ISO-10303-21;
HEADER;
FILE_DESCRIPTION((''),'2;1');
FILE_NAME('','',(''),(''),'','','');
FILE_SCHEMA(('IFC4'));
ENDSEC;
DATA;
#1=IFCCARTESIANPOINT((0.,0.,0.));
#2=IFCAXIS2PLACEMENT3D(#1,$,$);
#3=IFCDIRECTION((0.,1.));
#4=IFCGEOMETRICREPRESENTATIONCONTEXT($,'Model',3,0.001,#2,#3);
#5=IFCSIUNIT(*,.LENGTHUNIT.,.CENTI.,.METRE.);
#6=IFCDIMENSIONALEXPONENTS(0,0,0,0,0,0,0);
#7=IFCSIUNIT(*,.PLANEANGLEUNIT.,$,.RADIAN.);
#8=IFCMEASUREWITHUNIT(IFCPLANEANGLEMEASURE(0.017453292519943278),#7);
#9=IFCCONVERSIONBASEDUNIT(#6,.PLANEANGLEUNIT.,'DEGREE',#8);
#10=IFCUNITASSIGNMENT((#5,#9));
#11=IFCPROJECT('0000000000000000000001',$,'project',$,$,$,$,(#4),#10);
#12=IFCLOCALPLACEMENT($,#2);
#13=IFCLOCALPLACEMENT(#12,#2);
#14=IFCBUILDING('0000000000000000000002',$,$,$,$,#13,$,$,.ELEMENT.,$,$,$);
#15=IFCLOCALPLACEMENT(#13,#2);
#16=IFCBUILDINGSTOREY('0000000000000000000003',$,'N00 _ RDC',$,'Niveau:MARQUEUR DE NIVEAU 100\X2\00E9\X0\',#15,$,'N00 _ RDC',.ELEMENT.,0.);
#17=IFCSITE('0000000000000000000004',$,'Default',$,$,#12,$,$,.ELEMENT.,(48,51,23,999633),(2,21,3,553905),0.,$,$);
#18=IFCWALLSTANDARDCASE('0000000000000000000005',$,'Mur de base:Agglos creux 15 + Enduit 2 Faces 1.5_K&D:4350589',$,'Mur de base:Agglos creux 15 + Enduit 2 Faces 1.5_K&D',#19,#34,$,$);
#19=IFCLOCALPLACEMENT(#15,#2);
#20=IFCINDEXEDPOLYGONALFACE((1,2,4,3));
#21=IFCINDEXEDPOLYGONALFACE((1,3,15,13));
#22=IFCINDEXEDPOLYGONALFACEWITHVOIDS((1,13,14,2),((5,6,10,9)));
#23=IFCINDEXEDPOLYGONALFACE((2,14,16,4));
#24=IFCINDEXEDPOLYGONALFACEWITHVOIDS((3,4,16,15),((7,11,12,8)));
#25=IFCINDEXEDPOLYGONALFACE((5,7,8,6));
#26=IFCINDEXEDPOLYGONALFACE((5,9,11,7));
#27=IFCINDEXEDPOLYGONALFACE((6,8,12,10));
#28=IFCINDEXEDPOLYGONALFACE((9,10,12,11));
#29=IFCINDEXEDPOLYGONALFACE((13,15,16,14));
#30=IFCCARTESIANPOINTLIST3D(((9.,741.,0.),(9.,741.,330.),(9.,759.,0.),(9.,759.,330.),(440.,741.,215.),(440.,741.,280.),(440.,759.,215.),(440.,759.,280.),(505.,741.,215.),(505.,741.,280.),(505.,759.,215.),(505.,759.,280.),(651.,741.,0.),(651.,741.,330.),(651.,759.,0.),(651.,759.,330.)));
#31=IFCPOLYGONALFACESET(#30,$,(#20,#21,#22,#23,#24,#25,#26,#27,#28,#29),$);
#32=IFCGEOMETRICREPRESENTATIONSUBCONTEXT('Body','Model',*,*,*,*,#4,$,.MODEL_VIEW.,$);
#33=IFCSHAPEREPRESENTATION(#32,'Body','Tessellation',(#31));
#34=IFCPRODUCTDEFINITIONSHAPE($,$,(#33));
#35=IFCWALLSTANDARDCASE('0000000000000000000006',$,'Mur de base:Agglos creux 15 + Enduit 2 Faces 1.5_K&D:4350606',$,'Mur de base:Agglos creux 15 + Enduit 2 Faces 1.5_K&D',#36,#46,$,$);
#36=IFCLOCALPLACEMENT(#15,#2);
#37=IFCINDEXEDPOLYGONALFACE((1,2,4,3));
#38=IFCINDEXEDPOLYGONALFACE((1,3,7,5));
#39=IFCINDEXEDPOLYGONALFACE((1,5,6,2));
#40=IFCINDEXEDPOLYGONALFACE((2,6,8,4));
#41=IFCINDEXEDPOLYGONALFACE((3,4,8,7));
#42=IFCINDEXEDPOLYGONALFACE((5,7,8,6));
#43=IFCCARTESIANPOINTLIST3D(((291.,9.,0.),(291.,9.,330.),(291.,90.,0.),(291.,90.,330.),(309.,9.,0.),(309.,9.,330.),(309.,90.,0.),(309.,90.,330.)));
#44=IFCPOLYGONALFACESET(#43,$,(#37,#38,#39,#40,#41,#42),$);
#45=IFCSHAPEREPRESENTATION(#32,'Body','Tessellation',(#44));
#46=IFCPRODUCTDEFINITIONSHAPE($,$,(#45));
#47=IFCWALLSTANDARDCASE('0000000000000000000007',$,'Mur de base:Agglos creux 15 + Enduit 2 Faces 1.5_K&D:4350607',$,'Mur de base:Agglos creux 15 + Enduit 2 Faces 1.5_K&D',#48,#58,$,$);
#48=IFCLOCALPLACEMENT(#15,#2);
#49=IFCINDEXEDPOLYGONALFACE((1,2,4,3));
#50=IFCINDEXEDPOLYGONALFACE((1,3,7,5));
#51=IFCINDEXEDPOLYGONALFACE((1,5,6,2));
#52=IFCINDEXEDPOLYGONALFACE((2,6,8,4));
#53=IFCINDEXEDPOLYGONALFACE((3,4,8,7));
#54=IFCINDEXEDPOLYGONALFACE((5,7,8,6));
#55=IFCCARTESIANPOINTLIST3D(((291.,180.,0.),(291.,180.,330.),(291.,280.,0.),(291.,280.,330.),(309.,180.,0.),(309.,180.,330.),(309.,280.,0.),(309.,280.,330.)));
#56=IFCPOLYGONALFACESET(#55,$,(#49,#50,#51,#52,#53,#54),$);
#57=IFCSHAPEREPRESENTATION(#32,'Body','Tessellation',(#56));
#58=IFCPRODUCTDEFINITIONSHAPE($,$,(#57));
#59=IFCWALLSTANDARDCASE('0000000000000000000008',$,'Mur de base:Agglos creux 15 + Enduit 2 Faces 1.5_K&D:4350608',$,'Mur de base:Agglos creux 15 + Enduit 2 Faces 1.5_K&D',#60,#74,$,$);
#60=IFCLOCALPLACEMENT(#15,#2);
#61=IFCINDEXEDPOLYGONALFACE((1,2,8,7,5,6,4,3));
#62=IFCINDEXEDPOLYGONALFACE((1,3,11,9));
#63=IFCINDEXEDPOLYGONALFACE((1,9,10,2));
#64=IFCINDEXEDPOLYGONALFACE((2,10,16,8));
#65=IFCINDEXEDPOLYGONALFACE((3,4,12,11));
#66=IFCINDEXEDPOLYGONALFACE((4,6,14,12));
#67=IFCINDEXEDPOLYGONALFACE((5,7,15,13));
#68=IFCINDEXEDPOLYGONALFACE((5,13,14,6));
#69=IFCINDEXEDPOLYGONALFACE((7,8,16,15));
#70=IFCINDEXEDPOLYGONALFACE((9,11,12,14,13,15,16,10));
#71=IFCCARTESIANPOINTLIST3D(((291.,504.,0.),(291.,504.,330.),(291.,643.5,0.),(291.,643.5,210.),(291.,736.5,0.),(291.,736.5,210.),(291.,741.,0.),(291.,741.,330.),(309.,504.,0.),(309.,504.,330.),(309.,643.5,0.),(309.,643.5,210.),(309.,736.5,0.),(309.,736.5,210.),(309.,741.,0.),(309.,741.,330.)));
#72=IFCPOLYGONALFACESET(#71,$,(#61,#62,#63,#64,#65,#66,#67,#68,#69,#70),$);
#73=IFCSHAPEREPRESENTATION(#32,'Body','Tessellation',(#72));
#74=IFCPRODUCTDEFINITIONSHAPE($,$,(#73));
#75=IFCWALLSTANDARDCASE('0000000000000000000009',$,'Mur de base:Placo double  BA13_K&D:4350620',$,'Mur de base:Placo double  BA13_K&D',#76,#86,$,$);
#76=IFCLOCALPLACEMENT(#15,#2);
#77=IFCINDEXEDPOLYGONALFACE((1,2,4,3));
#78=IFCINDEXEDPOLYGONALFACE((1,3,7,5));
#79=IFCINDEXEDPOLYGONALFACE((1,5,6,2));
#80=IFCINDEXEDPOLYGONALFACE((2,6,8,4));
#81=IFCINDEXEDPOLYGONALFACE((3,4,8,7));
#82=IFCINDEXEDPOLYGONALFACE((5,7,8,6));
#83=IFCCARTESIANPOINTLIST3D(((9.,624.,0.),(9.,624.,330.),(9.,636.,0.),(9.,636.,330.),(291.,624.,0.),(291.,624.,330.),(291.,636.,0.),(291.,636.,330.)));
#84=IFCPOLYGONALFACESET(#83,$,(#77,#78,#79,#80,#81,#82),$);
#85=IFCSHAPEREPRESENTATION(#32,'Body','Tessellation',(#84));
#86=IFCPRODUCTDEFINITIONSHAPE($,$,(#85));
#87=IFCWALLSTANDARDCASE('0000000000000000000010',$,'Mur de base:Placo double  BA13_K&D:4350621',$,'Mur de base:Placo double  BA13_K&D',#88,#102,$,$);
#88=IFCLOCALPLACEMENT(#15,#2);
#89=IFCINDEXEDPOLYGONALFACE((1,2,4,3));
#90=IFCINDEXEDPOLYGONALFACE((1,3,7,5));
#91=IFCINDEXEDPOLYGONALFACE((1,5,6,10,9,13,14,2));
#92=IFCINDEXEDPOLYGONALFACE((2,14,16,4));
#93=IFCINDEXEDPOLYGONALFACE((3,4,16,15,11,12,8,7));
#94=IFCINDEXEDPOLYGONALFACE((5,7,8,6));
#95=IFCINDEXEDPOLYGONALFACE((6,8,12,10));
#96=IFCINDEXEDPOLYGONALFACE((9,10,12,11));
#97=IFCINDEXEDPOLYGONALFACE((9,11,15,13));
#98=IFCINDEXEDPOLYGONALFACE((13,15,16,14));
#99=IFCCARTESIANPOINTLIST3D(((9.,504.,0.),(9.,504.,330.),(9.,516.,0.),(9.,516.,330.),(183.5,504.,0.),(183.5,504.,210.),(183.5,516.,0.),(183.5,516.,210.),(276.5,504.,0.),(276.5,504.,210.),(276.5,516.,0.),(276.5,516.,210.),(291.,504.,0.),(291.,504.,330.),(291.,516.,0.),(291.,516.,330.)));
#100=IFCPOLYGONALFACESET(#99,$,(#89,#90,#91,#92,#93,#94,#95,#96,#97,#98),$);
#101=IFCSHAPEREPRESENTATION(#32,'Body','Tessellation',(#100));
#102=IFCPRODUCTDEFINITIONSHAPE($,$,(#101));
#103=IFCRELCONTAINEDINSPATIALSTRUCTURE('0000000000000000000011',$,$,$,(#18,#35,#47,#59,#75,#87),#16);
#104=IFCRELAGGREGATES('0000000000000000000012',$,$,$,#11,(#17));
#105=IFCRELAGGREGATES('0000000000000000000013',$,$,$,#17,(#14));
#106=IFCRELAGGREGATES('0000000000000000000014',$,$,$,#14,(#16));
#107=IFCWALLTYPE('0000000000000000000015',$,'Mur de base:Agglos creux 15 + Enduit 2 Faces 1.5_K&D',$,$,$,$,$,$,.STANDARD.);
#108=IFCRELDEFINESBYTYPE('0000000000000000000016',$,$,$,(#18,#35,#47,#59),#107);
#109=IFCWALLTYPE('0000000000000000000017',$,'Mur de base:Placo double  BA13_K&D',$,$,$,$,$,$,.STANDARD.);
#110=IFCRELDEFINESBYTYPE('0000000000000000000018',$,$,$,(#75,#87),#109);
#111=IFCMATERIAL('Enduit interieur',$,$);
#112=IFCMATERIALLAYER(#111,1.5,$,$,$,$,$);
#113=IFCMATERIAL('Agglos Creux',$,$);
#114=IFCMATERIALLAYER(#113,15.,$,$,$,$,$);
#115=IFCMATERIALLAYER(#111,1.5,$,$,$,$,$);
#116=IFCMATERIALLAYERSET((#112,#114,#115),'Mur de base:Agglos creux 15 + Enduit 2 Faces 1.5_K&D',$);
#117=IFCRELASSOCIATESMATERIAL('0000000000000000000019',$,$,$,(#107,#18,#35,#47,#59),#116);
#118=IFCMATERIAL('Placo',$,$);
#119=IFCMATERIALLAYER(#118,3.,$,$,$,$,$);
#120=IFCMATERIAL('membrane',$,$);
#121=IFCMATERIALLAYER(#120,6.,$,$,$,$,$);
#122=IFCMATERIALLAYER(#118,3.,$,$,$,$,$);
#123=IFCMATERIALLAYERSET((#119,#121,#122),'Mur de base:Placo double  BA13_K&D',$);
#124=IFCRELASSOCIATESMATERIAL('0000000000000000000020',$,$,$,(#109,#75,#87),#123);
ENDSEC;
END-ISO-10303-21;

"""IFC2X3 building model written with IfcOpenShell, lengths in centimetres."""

from ifc_helpers import new_model, entity, si_unit, converted_unit, direction, frame, frame_2d, origin, place, context, subcontext, project, spatial, rectangle, extrude, material, layer, layer_set, layer_usage, type_object, element, save


model = new_model("IFC2X3")

# Units and contexts
model_context = context("Model", 3, precision=0.001, world=origin(), true_north=direction((0.0, 1.0)))
body_context = subcontext(model_context, "Body", "Model", "MODEL_VIEW")
ifc_project = project(units=[si_unit("LENGTHUNIT", "METRE", prefix="CENTI"), converted_unit("PLANEANGLEUNIT", "DEGREE", entity("IfcPlaneAngleMeasure", 0.017453292519943278), si_unit("PLANEANGLEUNIT", "RADIAN"), dimensions=[0, 0, 0, 0, 0, 0, 0])], contexts=[model_context])

# Site, building, storey
site_placement = place(None, origin())
site = spatial("IfcSite", under=ifc_project, at=site_placement, Name="Default", CompositionType="ELEMENT", RefLatitude=(48, 51, 23, 999633), RefLongitude=(2, 21, 3, 553905), RefElevation=0.0)
building_placement = place(site_placement, origin())
building = spatial("IfcBuilding", under=site, at=building_placement, CompositionType="ELEMENT")
storey_placement = place(building_placement, origin())
storey = spatial("IfcBuildingStorey", under=building, at=storey_placement, Name="N00 _ RDC", ObjectType="Niveau:MARQUEUR DE NIVEAU 100é", LongName="N00 _ RDC", CompositionType="ELEMENT", Elevation=0.0)

# Wall, opening
ifc_material_1 = material(Name="Enduit interieur")
ifc_layer_1 = layer(ifc_material_1, 1.5)
ifc_material_2 = material(Name="Agglos Creux")
ifc_layer_2 = layer(ifc_material_2, 15.0)
ifc_layer_3 = layer(ifc_material_1, 1.5)
ifc_layer_set_1 = layer_set([ifc_layer_1, ifc_layer_2, ifc_layer_3], Name="Mur de base:Agglos creux 15 + Enduit 2 Faces 1.5_K&D")
ifc_layer_usage_1 = layer_usage(ifc_layer_set_1, "AXIS2", "NEGATIVE", 9.0)
wall_type_1 = type_object("IfcWallType", Name="Mur de base:Agglos creux 15 + Enduit 2 Faces 1.5_K&D", PredefinedType="STANDARD", material=ifc_layer_set_1)
wall_1_placement = place(storey_placement, frame((9.0, 750.0, 0.0)))
wall_1 = element("IfcWallStandardCase", 1, at=wall_1_placement, inside=storey, type_object=wall_type_1, material=ifc_layer_usage_1, Name="Mur de base:Agglos creux 15 + Enduit 2 Faces 1.5_K&D:4350589", ObjectType="Mur de base:Agglos creux 15 + Enduit 2 Faces 1.5_K&D", context=body_context, shape_type="SweptSolid", body=[
    extrude(rectangle(XDim=642.0, YDim=18.0, at=frame_2d((321.0, 0.0), x_axis=(-1.0, 0.0))), origin(), (0.0, 0.0, 1.0), 330.0),
])
opening_1_placement = place(wall_1_placement, origin())
element("IfcOpeningElement", 2, at=opening_1_placement, cuts=wall_1, ObjectType="Opening", context=body_context, shape_type="SweptSolid", body=[
    extrude(rectangle(XDim=65.0, YDim=65.0, at=frame_2d((0.0, 0.0), x_axis=(1.0, 0.0))), frame((463.5, -9.0, 247.5), z_axis=(0.0, 1.0, 0.0), x_axis=(0.0, 0.0, -1.0)), (0.0, 0.0, 1.0), 18.0),
])

# Walls
ifc_layer_usage_2 = layer_usage(ifc_layer_set_1, "AXIS2", "NEGATIVE", 9.0)
wall_2_placement = place(storey_placement, frame((300.0, 9.0, 0.0), z_axis=(0.0, 0.0, 1.0), x_axis=(0.0, 1.0, 0.0)))
element("IfcWallStandardCase", 3, at=wall_2_placement, inside=storey, type_object=wall_type_1, material=ifc_layer_usage_2, Name="Mur de base:Agglos creux 15 + Enduit 2 Faces 1.5_K&D:4350606", ObjectType="Mur de base:Agglos creux 15 + Enduit 2 Faces 1.5_K&D", context=body_context, shape_type="SweptSolid", body=[
    extrude(rectangle(XDim=81.0, YDim=18.0, at=frame_2d((40.5, 0.0), x_axis=(-1.0, 0.0))), origin(), (0.0, 0.0, 1.0), 330.0),
])
ifc_layer_usage_3 = layer_usage(ifc_layer_set_1, "AXIS2", "NEGATIVE", 9.0)
wall_3_placement = place(storey_placement, frame((300.0, 180.0, 0.0), z_axis=(0.0, 0.0, 1.0), x_axis=(0.0, 1.0, 0.0)))
element("IfcWallStandardCase", 4, at=wall_3_placement, inside=storey, type_object=wall_type_1, material=ifc_layer_usage_3, Name="Mur de base:Agglos creux 15 + Enduit 2 Faces 1.5_K&D:4350607", ObjectType="Mur de base:Agglos creux 15 + Enduit 2 Faces 1.5_K&D", context=body_context, shape_type="SweptSolid", body=[
    extrude(rectangle(XDim=100.0, YDim=18.0, at=frame_2d((50.0, 0.0), x_axis=(-1.0, 0.0))), origin(), (0.0, 0.0, 1.0), 330.0),
])

# Wall, opening
ifc_layer_usage_4 = layer_usage(ifc_layer_set_1, "AXIS2", "POSITIVE", -9.0)
wall_4_placement = place(storey_placement, frame((300.0, 504.0, 0.0), z_axis=(0.0, 0.0, 1.0), x_axis=(0.0, 1.0, 0.0)))
wall_4 = element("IfcWallStandardCase", 5, at=wall_4_placement, inside=storey, type_object=wall_type_1, material=ifc_layer_usage_4, Name="Mur de base:Agglos creux 15 + Enduit 2 Faces 1.5_K&D:4350608", ObjectType="Mur de base:Agglos creux 15 + Enduit 2 Faces 1.5_K&D", context=body_context, shape_type="SweptSolid", body=[
    extrude(rectangle(XDim=237.0, YDim=18.0, at=frame_2d((118.5, 0.0), x_axis=(1.0, 0.0))), origin(), (0.0, 0.0, 1.0), 330.0),
])
opening_2_placement = place(wall_4_placement, frame((139.5, -9.0, 0.0)))
element("IfcOpeningElement", 6, at=opening_2_placement, cuts=wall_4, ObjectType="Opening", context=body_context, shape_type="SweptSolid", body=[
    extrude(rectangle(XDim=210.0, YDim=93.0, at=frame_2d((105.0, 46.5), x_axis=(1.0, 0.0))), frame((0.0, 0.0, 0.0), z_axis=(0.0, 1.0, 0.0), x_axis=(0.0, 0.0, 1.0)), (0.0, 0.0, 1.0), 18.0),
])

# Wall
ifc_material_3 = material(Name="Placo")
ifc_layer_4 = layer(ifc_material_3, 3.0)
ifc_material_4 = material(Name="membrane")
ifc_layer_5 = layer(ifc_material_4, 6.0)
ifc_layer_6 = layer(ifc_material_3, 3.0)
ifc_layer_set_2 = layer_set([ifc_layer_4, ifc_layer_5, ifc_layer_6], Name="Mur de base:Placo double  BA13_K&D")
ifc_layer_usage_5 = layer_usage(ifc_layer_set_2, "AXIS2", "NEGATIVE", 6.0)
wall_type_2 = type_object("IfcWallType", Name="Mur de base:Placo double  BA13_K&D", PredefinedType="STANDARD", material=ifc_layer_set_2)
wall_5_placement = place(storey_placement, frame((9.0, 630.0, 0.0)))
element("IfcWallStandardCase", 7, at=wall_5_placement, inside=storey, type_object=wall_type_2, material=ifc_layer_usage_5, Name="Mur de base:Placo double  BA13_K&D:4350620", ObjectType="Mur de base:Placo double  BA13_K&D", context=body_context, shape_type="SweptSolid", body=[
    extrude(rectangle(XDim=282.0, YDim=12.0, at=frame_2d((141.0, 0.0), x_axis=(-1.0, 0.0))), origin(), (0.0, 0.0, 1.0), 330.0),
])

# Wall, opening
ifc_layer_usage_6 = layer_usage(ifc_layer_set_2, "AXIS2", "POSITIVE", -6.0)
wall_6_placement = place(storey_placement, frame((9.0, 510.0, 0.0)))
wall_6 = element("IfcWallStandardCase", 8, at=wall_6_placement, inside=storey, type_object=wall_type_2, material=ifc_layer_usage_6, Name="Mur de base:Placo double  BA13_K&D:4350621", ObjectType="Mur de base:Placo double  BA13_K&D", context=body_context, shape_type="SweptSolid", body=[
    extrude(rectangle(XDim=282.0, YDim=12.0, at=frame_2d((141.0, 0.0), x_axis=(-1.0, 0.0))), origin(), (0.0, 0.0, 1.0), 330.0),
])
opening_3_placement = place(wall_6_placement, frame((174.5, -6.0, 0.0)))
element("IfcOpeningElement", 9, at=opening_3_placement, cuts=wall_6, ObjectType="Opening", context=body_context, shape_type="SweptSolid", body=[
    extrude(rectangle(XDim=210.0, YDim=93.0, at=frame_2d((105.0, 46.5), x_axis=(1.0, 0.0))), frame((0.0, 0.0, 0.0), z_axis=(0.0, 1.0, 0.0), x_axis=(0.0, 0.0, 1.0)), (0.0, 0.0, 1.0), 12.0),
])

save(model, "model.ifc")
